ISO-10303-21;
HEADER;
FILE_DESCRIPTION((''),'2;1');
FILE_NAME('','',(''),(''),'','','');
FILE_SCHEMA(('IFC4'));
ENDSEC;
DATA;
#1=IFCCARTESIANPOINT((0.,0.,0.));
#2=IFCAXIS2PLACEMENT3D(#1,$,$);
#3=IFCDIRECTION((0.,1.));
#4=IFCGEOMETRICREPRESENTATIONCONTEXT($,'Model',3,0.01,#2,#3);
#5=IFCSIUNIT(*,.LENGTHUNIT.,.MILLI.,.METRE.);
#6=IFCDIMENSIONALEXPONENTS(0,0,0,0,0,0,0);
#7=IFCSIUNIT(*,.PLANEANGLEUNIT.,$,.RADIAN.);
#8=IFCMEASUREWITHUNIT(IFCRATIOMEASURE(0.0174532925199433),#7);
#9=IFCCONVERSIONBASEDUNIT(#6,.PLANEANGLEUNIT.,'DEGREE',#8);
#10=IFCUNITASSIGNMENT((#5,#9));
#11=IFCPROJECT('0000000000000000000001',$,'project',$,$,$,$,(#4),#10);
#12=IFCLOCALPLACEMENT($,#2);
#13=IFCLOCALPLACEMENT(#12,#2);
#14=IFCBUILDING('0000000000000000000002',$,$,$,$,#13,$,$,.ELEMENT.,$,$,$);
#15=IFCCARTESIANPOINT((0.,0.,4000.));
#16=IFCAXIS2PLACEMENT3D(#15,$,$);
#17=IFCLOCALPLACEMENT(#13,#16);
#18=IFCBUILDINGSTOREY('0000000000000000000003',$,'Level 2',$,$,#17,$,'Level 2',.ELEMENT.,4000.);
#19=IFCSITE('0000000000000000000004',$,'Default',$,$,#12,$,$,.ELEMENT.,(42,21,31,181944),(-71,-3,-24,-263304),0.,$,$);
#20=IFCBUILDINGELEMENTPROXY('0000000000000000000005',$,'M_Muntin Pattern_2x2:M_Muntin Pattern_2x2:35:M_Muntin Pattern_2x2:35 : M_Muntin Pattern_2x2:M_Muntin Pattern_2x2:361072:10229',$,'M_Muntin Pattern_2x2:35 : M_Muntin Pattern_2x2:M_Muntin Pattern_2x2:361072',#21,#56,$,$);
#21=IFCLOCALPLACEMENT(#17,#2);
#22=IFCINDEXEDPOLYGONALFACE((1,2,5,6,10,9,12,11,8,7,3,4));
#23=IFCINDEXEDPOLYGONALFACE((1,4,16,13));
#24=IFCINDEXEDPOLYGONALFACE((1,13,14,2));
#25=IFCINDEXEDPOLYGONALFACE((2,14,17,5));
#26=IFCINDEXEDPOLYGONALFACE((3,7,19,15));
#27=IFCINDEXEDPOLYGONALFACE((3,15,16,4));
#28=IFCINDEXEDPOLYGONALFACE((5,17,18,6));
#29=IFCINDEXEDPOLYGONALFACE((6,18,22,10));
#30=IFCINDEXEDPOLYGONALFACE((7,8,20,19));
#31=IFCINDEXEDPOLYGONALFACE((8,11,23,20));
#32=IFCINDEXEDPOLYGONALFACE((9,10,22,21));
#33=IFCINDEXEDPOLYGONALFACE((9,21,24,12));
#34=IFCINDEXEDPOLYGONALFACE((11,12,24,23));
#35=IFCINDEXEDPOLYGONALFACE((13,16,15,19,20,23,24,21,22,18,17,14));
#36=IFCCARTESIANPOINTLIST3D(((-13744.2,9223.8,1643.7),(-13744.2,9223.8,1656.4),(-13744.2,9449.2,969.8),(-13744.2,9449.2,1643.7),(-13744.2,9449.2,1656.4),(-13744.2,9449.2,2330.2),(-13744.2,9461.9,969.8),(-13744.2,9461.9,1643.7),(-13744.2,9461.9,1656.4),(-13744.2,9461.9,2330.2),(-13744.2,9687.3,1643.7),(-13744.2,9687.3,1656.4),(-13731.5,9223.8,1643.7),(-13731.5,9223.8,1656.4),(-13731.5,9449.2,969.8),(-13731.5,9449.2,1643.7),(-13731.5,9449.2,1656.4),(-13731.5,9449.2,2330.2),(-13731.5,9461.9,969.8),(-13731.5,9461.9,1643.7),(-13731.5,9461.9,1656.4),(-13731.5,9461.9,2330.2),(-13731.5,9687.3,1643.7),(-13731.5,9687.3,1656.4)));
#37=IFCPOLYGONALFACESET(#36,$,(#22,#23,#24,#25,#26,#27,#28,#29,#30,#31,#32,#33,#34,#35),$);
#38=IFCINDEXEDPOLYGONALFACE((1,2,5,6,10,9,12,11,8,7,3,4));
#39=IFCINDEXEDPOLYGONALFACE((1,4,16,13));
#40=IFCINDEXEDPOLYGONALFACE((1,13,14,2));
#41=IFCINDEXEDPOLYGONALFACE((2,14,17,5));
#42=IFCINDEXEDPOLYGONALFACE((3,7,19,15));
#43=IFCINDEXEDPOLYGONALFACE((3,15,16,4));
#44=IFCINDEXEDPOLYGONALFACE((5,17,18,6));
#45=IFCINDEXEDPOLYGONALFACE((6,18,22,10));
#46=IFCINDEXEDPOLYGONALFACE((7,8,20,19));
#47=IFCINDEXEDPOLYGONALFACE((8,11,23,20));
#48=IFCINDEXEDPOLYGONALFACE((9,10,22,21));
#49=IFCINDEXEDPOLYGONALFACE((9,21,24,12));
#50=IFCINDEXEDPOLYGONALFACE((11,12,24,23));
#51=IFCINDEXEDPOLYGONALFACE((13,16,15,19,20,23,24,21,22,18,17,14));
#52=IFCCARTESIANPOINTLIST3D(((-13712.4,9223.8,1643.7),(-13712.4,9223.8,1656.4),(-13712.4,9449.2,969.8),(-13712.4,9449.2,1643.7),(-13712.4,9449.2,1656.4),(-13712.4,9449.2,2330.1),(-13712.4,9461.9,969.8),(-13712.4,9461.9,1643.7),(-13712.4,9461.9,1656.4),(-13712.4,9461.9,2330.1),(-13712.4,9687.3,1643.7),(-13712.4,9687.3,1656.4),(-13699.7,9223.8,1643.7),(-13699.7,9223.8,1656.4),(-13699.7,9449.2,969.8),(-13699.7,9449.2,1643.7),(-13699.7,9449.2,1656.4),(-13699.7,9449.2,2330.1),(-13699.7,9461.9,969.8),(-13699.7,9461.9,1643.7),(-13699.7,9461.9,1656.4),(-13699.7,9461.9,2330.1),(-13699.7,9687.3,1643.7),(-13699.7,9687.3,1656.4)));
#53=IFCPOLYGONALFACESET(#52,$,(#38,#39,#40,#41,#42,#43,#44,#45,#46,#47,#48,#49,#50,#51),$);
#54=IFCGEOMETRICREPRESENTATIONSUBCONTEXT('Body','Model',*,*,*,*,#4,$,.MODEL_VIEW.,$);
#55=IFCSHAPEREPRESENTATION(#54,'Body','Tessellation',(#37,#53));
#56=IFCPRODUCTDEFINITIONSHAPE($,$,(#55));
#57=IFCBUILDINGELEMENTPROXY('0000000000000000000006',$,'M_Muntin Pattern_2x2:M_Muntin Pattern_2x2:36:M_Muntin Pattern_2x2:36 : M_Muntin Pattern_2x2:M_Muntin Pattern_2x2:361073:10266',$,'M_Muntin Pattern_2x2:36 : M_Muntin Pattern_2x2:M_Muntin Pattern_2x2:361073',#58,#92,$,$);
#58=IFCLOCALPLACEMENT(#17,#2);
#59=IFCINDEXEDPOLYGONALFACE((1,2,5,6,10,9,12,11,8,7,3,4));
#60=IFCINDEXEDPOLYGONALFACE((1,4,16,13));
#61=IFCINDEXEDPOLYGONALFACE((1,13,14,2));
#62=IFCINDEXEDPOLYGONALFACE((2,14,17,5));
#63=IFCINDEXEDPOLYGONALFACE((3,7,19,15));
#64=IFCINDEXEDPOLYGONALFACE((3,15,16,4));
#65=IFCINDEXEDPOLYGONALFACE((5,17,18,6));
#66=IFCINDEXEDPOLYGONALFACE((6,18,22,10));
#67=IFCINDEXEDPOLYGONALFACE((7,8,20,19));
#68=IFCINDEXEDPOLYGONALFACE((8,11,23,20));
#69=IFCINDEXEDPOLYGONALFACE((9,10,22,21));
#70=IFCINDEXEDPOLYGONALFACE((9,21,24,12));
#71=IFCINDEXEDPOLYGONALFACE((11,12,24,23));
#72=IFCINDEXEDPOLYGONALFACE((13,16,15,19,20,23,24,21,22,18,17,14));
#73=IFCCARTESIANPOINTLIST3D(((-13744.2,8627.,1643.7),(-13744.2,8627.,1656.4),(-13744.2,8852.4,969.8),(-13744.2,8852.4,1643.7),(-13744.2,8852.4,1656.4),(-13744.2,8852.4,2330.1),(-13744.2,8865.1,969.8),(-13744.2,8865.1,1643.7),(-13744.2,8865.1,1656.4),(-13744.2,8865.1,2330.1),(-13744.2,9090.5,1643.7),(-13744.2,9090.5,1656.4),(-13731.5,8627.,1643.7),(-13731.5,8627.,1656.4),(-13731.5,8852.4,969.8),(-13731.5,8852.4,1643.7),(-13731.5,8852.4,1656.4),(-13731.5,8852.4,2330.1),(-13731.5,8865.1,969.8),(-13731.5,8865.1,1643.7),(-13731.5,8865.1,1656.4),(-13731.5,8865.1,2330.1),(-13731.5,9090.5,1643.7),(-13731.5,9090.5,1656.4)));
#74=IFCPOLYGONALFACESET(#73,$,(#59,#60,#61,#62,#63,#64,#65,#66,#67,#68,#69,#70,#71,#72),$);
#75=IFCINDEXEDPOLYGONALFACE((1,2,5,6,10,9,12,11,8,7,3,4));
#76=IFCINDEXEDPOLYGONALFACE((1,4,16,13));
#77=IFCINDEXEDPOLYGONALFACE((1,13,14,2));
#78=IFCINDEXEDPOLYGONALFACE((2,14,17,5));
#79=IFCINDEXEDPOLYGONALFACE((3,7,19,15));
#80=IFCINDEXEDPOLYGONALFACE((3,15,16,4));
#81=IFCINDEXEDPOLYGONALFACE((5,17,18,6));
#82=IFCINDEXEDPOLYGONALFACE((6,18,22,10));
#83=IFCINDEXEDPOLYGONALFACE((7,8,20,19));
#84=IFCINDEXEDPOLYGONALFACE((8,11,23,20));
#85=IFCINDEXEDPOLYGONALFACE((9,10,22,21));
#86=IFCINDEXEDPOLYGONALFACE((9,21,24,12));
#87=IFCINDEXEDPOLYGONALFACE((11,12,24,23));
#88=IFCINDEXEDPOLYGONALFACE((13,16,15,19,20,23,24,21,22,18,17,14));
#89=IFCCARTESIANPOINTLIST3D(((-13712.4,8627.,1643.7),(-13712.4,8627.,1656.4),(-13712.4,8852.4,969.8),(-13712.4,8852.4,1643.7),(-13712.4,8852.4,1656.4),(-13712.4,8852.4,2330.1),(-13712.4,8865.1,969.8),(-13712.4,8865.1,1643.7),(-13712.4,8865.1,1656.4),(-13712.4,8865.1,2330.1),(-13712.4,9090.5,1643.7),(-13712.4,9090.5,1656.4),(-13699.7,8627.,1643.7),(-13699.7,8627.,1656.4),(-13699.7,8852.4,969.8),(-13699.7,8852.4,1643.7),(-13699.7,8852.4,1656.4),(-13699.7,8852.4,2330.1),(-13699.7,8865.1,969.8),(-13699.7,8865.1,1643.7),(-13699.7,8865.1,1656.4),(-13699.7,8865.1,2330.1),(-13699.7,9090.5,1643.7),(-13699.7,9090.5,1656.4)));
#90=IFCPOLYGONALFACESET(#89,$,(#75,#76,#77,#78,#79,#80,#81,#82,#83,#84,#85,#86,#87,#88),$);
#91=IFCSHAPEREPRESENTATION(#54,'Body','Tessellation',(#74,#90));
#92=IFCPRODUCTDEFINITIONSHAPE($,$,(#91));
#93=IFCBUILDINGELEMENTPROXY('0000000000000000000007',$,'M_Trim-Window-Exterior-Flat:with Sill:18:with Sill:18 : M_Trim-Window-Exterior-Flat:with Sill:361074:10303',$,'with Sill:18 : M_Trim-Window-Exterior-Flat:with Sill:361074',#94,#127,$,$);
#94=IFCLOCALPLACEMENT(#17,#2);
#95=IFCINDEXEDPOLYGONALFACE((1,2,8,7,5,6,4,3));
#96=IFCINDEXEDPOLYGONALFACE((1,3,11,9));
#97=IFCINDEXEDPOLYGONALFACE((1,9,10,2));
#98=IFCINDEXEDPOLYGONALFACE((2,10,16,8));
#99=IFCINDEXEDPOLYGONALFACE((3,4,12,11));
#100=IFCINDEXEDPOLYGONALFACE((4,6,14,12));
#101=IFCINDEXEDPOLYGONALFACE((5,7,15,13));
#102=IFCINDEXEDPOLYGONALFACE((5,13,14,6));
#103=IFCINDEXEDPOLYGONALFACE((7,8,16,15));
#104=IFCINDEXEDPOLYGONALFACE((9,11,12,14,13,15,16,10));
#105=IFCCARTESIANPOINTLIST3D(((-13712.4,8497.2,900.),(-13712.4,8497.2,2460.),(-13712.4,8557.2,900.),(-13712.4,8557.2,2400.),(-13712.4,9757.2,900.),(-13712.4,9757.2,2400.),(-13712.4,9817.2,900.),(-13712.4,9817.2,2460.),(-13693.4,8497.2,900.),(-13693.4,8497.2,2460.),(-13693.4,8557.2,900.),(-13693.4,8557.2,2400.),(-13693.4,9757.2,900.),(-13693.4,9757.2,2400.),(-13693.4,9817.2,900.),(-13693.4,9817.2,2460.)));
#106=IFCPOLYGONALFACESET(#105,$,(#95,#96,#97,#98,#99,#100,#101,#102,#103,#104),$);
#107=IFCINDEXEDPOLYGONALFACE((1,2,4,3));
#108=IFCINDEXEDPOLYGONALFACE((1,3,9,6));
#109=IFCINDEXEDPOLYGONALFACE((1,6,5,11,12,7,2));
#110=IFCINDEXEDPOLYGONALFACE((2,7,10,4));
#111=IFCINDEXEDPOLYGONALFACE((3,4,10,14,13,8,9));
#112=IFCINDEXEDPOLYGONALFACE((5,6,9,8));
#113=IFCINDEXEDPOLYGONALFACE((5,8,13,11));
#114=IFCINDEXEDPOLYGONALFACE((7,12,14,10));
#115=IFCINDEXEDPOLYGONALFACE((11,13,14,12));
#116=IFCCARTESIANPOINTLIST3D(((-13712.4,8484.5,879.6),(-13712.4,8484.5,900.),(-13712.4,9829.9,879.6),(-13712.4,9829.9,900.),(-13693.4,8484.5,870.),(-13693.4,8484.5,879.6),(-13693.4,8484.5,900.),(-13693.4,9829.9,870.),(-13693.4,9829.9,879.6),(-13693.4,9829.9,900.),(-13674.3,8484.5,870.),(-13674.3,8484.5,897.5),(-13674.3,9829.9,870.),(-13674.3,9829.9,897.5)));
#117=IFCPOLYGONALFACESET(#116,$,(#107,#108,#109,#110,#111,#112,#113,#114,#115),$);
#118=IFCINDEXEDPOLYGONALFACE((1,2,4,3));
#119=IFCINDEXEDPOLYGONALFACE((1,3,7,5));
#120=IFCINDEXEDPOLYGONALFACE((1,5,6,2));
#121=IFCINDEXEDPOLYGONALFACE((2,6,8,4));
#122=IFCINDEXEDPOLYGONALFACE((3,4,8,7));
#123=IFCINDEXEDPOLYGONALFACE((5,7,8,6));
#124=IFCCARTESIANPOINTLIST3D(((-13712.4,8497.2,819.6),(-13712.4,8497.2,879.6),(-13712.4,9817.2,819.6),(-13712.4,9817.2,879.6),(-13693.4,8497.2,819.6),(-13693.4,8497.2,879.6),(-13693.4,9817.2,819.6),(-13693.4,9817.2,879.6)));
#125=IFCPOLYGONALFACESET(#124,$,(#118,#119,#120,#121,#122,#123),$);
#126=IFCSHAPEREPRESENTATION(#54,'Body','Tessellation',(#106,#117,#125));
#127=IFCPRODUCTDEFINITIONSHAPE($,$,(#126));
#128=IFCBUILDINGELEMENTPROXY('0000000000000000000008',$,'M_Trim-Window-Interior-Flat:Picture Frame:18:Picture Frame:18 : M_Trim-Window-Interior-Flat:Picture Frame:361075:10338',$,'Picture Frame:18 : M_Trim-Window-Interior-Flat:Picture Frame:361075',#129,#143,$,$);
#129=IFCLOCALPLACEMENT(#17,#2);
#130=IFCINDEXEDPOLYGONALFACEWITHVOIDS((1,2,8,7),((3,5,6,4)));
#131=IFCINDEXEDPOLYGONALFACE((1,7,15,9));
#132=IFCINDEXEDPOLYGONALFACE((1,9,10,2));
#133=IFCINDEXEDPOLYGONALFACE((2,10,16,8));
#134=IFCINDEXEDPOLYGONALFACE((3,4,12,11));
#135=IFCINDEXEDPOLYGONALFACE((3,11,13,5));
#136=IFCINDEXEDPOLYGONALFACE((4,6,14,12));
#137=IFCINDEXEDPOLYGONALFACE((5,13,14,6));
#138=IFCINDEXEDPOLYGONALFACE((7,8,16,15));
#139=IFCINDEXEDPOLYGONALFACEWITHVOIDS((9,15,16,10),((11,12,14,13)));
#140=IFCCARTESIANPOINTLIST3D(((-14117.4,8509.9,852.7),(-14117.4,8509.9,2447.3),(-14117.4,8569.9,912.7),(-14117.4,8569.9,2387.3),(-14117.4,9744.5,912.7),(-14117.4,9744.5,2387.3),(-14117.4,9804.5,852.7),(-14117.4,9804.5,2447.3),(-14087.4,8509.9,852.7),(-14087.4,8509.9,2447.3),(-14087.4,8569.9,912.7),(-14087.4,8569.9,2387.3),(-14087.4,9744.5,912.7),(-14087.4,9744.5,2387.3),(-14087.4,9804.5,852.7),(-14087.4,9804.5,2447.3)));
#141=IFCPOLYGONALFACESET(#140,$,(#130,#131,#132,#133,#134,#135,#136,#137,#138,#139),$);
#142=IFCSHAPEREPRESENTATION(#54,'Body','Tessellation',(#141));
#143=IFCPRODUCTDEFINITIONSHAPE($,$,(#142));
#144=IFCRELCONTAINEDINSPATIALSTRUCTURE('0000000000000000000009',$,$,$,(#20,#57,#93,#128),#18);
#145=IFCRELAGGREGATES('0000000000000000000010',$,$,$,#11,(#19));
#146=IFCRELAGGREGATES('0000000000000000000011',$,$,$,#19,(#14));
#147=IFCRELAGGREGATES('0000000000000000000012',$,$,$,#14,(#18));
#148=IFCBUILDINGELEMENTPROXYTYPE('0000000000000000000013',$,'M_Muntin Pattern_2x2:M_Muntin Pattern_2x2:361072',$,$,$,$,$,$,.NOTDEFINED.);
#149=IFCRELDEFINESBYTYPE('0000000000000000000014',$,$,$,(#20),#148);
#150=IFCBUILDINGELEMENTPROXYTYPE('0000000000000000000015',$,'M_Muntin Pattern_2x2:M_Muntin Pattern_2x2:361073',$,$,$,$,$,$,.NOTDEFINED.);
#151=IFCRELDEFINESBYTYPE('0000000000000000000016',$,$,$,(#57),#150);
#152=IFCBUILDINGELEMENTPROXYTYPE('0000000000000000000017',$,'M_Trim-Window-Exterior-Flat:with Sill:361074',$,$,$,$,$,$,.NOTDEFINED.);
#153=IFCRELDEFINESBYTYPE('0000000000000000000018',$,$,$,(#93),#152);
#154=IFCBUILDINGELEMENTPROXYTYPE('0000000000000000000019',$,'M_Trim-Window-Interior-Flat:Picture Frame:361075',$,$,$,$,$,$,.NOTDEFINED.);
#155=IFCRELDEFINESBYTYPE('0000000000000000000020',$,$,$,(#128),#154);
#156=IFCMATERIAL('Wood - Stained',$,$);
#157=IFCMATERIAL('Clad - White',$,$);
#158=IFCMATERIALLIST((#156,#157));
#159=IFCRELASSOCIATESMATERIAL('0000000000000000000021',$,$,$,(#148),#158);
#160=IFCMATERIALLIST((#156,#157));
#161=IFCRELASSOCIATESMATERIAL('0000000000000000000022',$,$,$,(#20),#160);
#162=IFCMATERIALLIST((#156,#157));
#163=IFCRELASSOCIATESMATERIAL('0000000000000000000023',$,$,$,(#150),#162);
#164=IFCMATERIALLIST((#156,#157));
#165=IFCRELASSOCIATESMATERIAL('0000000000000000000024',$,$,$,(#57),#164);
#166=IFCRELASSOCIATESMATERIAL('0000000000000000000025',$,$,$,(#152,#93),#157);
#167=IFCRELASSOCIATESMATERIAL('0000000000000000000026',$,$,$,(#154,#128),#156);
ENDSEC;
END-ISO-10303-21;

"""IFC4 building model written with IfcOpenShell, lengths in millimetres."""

from ifc_helpers import new_model, entity, si_unit, converted_unit, direction, frame, frame_2d, origin, place, context, subcontext, project, spatial, polyline, rectangle, outline, extrude, source, transform, mapped, material, material_list, type_object, type_shapes, element, save


model = new_model("IFC4")

# Units and contexts
model_context = context("Model", 3, precision=0.01, world=origin(), true_north=direction((0.0, 1.0)))
body_context = subcontext(model_context, "Body", "Model", "MODEL_VIEW")
ifc_project = project(units=[si_unit("LENGTHUNIT", "METRE", prefix="MILLI"), converted_unit("PLANEANGLEUNIT", "DEGREE", entity("IfcRatioMeasure", 0.0174532925199433), si_unit("PLANEANGLEUNIT", "RADIAN"), dimensions=[0, 0, 0, 0, 0, 0, 0])], contexts=[model_context])

# Site, building, storey
site_placement = place(None, origin())
site = spatial("IfcSite", under=ifc_project, at=site_placement, Name="Default", CompositionType="ELEMENT", RefLatitude=(42, 21, 31, 181944), RefLongitude=(-71, -3, -24, -263304), RefElevation=0.0)
building_placement = place(site_placement, origin())
building = spatial("IfcBuilding", under=site, at=building_placement, CompositionType="ELEMENT")
storey_placement = place(building_placement, frame((0.0, 0.0, 4000.0)))
storey = spatial("IfcBuildingStorey", under=building, at=storey_placement, Name="Level 2", LongName="Level 2", CompositionType="ELEMENT", Elevation=4000.0)

# Building element proxies
ifc_material_1 = material(Name="Wood - Stained")
ifc_material_2 = material(Name="Clad - White")
ifc_material_list_1 = material_list([ifc_material_1, ifc_material_2])
ifc_material_list_2 = material_list([ifc_material_1, ifc_material_2])
building_element_proxy_type_1 = type_object("IfcBuildingElementProxyType", Name="M_Muntin Pattern_2x2:M_Muntin Pattern_2x2:361072", PredefinedType="NOTDEFINED", material=ifc_material_list_2)
shared_shape_1 = source(origin(), body_context, "Body", "SweptSolid", [
    extrude(outline(polyline([(-6.4, -680.2), (6.3, -680.2), (6.3, -6.4), (231.7, -6.4), (231.7, 6.3), (6.3, 6.3), (6.3, 680.2), (-6.4, 680.2), (-6.4, 6.3), (-231.7, 6.3), (-231.7, -6.4), (-6.4, -6.4), (-6.4, -680.2)])), frame((-13744.2, 9455.6, 5650.0), z_axis=(1.0, 0.0, 0.0), x_axis=(0.0, -1.0, 0.0)), (0.0, 0.0, 1.0), 12.7),
    extrude(outline(polyline([(-6.4, -680.1), (6.3, -680.1), (6.3, -6.4), (231.7, -6.4), (231.7, 6.3), (6.3, 6.3), (6.3, 680.2), (-6.4, 680.2), (-6.4, 6.3), (-231.7, 6.3), (-231.7, -6.4), (-6.4, -6.4), (-6.4, -680.1)])), frame((-13712.4, 9455.6, 5650.0), z_axis=(1.0, 0.0, 0.0), x_axis=(0.0, -1.0, 0.0)), (0.0, 0.0, 1.0), 12.7),
])
type_shapes(building_element_proxy_type_1, [shared_shape_1])
proxy_1_placement = place(storey_placement, frame((0.0, 0.0, -4000.0)))
element("IfcBuildingElementProxy", 1, at=proxy_1_placement, inside=storey, type_object=building_element_proxy_type_1, material=ifc_material_list_1, Name="M_Muntin Pattern_2x2:M_Muntin Pattern_2x2:35:M_Muntin Pattern_2x2:35 : M_Muntin Pattern_2x2:M_Muntin Pattern_2x2:361072:10229", ObjectType="M_Muntin Pattern_2x2:35 : M_Muntin Pattern_2x2:M_Muntin Pattern_2x2:361072", context=body_context, shape_type="MappedRepresentation", body=[
    mapped(shared_shape_1, transform((0.0, 0.0, 0.0), scale=1.0)),
])
ifc_material_list_3 = material_list([ifc_material_1, ifc_material_2])
ifc_material_list_4 = material_list([ifc_material_1, ifc_material_2])
building_element_proxy_type_2 = type_object("IfcBuildingElementProxyType", Name="M_Muntin Pattern_2x2:M_Muntin Pattern_2x2:361073", PredefinedType="NOTDEFINED", material=ifc_material_list_4)
shared_shape_2 = source(origin(), body_context, "Body", "SweptSolid", [
    extrude(outline(polyline([(-680.1, 6.4), (-680.1, -6.3), (-6.4, -6.3), (-6.4, -231.7), (6.3, -231.7), (6.3, -6.3), (680.2, -6.3), (680.2, 6.4), (6.3, 6.4), (6.3, 231.7), (-6.4, 231.7), (-6.4, 6.4), (-680.1, 6.4)])), frame((-13744.2, 8858.7, 5650.0), z_axis=(-1.0, 0.0, 0.0), x_axis=(0.0, 0.0, -1.0)), (0.0, 0.0, -1.0), 12.7),
    extrude(outline(polyline([(-680.1, 6.4), (-680.1, -6.3), (-6.4, -6.3), (-6.4, -231.7), (6.3, -231.7), (6.3, -6.3), (680.2, -6.3), (680.2, 6.4), (6.3, 6.4), (6.3, 231.7), (-6.4, 231.7), (-6.4, 6.4), (-680.1, 6.4)])), frame((-13712.4, 8858.7, 5650.0), z_axis=(-1.0, 0.0, 0.0), x_axis=(0.0, 0.0, -1.0)), (0.0, 0.0, -1.0), 12.7),
])
type_shapes(building_element_proxy_type_2, [shared_shape_2])
proxy_2_placement = place(storey_placement, frame((0.0, 0.0, -4000.0)))
element("IfcBuildingElementProxy", 2, at=proxy_2_placement, inside=storey, type_object=building_element_proxy_type_2, material=ifc_material_list_3, Name="M_Muntin Pattern_2x2:M_Muntin Pattern_2x2:36:M_Muntin Pattern_2x2:36 : M_Muntin Pattern_2x2:M_Muntin Pattern_2x2:361073:10266", ObjectType="M_Muntin Pattern_2x2:36 : M_Muntin Pattern_2x2:M_Muntin Pattern_2x2:361073", context=body_context, shape_type="MappedRepresentation", body=[
    mapped(shared_shape_2, transform((0.0, 0.0, 0.0), scale=1.0)),
])
building_element_proxy_type_3 = type_object("IfcBuildingElementProxyType", Name="M_Trim-Window-Exterior-Flat:with Sill:361074", PredefinedType="NOTDEFINED", material=ifc_material_2)
shared_shape_3 = source(origin(), body_context, "Body", "SweptSolid", [
    extrude(outline(polyline([(-660.0, -765.0), (-600.0, -765.0), (-600.0, 735.0), (600.0, 735.0), (600.0, -765.0), (660.0, -765.0), (660.0, 795.0), (-660.0, 795.0), (-660.0, -765.0)])), frame((-13712.4, 9157.2, 5665.0), z_axis=(1.0, 0.0, 0.0), x_axis=(0.0, 1.0, 0.0)), (0.0, 0.0, 1.0), 19.1),
    extrude(outline(polyline([(-15.2, 0.0), (-15.2, -19.0), (12.3, -19.0), (14.8, 0.0), (14.8, 19.0), (-5.7, 19.0), (-5.7, 0.0), (-15.2, 0.0)])), frame((-13693.4, 8484.5, 4885.2), z_axis=(0.0, -1.0, 0.0), x_axis=(0.0, 0.0, 1.0)), (0.0, 0.0, -1.0), 1345.4),
    extrude(rectangle(XDim=19.1, YDim=1320.0, at=frame_2d((0.0, 0.0), x_axis=(1.0, 0.0))), frame((-13702.9, 9157.2, 4819.6), z_axis=(0.0, 0.0, 1.0), x_axis=(-1.0, 0.0, 0.0)), (0.0, 0.0, 1.0), 60.0),
])
type_shapes(building_element_proxy_type_3, [shared_shape_3])
proxy_3_placement = place(storey_placement, frame((0.0, 0.0, -4000.0)))
element("IfcBuildingElementProxy", 3, at=proxy_3_placement, inside=storey, type_object=building_element_proxy_type_3, material=ifc_material_2, Name="M_Trim-Window-Exterior-Flat:with Sill:18:with Sill:18 : M_Trim-Window-Exterior-Flat:with Sill:361074:10303", ObjectType="with Sill:18 : M_Trim-Window-Exterior-Flat:with Sill:361074", context=body_context, shape_type="MappedRepresentation", body=[
    mapped(shared_shape_3, transform((0.0, 0.0, 0.0), scale=1.0)),
])
building_element_proxy_type_4 = type_object("IfcBuildingElementProxyType", Name="M_Trim-Window-Interior-Flat:Picture Frame:361075", PredefinedType="NOTDEFINED", material=ifc_material_1)
shared_shape_4 = source(origin(), body_context, "Body", "SweptSolid", [
    extrude(outline(polyline([(-647.3, -797.3), (647.3, -797.3), (647.3, 797.3), (-647.3, 797.3), (-647.3, -797.3)]), holes=[polyline([(587.3, 737.3), (587.3, -737.3), (-587.3, -737.3), (-587.3, 737.3), (587.3, 737.3)])]), frame((-14117.4, 9157.2, 5650.0), z_axis=(1.0, 0.0, 0.0), x_axis=(0.0, -1.0, 0.0)), (0.0, 0.0, 1.0), 30.0),
])
type_shapes(building_element_proxy_type_4, [shared_shape_4])
proxy_4_placement = place(storey_placement, frame((0.0, 0.0, -4000.0)))
element("IfcBuildingElementProxy", 4, at=proxy_4_placement, inside=storey, type_object=building_element_proxy_type_4, material=ifc_material_1, Name="M_Trim-Window-Interior-Flat:Picture Frame:18:Picture Frame:18 : M_Trim-Window-Interior-Flat:Picture Frame:361075:10338", ObjectType="Picture Frame:18 : M_Trim-Window-Interior-Flat:Picture Frame:361075", context=body_context, shape_type="MappedRepresentation", body=[
    mapped(shared_shape_4, transform((0.0, 0.0, 0.0), scale=1.0)),
])

save(model, "model.ifc")
